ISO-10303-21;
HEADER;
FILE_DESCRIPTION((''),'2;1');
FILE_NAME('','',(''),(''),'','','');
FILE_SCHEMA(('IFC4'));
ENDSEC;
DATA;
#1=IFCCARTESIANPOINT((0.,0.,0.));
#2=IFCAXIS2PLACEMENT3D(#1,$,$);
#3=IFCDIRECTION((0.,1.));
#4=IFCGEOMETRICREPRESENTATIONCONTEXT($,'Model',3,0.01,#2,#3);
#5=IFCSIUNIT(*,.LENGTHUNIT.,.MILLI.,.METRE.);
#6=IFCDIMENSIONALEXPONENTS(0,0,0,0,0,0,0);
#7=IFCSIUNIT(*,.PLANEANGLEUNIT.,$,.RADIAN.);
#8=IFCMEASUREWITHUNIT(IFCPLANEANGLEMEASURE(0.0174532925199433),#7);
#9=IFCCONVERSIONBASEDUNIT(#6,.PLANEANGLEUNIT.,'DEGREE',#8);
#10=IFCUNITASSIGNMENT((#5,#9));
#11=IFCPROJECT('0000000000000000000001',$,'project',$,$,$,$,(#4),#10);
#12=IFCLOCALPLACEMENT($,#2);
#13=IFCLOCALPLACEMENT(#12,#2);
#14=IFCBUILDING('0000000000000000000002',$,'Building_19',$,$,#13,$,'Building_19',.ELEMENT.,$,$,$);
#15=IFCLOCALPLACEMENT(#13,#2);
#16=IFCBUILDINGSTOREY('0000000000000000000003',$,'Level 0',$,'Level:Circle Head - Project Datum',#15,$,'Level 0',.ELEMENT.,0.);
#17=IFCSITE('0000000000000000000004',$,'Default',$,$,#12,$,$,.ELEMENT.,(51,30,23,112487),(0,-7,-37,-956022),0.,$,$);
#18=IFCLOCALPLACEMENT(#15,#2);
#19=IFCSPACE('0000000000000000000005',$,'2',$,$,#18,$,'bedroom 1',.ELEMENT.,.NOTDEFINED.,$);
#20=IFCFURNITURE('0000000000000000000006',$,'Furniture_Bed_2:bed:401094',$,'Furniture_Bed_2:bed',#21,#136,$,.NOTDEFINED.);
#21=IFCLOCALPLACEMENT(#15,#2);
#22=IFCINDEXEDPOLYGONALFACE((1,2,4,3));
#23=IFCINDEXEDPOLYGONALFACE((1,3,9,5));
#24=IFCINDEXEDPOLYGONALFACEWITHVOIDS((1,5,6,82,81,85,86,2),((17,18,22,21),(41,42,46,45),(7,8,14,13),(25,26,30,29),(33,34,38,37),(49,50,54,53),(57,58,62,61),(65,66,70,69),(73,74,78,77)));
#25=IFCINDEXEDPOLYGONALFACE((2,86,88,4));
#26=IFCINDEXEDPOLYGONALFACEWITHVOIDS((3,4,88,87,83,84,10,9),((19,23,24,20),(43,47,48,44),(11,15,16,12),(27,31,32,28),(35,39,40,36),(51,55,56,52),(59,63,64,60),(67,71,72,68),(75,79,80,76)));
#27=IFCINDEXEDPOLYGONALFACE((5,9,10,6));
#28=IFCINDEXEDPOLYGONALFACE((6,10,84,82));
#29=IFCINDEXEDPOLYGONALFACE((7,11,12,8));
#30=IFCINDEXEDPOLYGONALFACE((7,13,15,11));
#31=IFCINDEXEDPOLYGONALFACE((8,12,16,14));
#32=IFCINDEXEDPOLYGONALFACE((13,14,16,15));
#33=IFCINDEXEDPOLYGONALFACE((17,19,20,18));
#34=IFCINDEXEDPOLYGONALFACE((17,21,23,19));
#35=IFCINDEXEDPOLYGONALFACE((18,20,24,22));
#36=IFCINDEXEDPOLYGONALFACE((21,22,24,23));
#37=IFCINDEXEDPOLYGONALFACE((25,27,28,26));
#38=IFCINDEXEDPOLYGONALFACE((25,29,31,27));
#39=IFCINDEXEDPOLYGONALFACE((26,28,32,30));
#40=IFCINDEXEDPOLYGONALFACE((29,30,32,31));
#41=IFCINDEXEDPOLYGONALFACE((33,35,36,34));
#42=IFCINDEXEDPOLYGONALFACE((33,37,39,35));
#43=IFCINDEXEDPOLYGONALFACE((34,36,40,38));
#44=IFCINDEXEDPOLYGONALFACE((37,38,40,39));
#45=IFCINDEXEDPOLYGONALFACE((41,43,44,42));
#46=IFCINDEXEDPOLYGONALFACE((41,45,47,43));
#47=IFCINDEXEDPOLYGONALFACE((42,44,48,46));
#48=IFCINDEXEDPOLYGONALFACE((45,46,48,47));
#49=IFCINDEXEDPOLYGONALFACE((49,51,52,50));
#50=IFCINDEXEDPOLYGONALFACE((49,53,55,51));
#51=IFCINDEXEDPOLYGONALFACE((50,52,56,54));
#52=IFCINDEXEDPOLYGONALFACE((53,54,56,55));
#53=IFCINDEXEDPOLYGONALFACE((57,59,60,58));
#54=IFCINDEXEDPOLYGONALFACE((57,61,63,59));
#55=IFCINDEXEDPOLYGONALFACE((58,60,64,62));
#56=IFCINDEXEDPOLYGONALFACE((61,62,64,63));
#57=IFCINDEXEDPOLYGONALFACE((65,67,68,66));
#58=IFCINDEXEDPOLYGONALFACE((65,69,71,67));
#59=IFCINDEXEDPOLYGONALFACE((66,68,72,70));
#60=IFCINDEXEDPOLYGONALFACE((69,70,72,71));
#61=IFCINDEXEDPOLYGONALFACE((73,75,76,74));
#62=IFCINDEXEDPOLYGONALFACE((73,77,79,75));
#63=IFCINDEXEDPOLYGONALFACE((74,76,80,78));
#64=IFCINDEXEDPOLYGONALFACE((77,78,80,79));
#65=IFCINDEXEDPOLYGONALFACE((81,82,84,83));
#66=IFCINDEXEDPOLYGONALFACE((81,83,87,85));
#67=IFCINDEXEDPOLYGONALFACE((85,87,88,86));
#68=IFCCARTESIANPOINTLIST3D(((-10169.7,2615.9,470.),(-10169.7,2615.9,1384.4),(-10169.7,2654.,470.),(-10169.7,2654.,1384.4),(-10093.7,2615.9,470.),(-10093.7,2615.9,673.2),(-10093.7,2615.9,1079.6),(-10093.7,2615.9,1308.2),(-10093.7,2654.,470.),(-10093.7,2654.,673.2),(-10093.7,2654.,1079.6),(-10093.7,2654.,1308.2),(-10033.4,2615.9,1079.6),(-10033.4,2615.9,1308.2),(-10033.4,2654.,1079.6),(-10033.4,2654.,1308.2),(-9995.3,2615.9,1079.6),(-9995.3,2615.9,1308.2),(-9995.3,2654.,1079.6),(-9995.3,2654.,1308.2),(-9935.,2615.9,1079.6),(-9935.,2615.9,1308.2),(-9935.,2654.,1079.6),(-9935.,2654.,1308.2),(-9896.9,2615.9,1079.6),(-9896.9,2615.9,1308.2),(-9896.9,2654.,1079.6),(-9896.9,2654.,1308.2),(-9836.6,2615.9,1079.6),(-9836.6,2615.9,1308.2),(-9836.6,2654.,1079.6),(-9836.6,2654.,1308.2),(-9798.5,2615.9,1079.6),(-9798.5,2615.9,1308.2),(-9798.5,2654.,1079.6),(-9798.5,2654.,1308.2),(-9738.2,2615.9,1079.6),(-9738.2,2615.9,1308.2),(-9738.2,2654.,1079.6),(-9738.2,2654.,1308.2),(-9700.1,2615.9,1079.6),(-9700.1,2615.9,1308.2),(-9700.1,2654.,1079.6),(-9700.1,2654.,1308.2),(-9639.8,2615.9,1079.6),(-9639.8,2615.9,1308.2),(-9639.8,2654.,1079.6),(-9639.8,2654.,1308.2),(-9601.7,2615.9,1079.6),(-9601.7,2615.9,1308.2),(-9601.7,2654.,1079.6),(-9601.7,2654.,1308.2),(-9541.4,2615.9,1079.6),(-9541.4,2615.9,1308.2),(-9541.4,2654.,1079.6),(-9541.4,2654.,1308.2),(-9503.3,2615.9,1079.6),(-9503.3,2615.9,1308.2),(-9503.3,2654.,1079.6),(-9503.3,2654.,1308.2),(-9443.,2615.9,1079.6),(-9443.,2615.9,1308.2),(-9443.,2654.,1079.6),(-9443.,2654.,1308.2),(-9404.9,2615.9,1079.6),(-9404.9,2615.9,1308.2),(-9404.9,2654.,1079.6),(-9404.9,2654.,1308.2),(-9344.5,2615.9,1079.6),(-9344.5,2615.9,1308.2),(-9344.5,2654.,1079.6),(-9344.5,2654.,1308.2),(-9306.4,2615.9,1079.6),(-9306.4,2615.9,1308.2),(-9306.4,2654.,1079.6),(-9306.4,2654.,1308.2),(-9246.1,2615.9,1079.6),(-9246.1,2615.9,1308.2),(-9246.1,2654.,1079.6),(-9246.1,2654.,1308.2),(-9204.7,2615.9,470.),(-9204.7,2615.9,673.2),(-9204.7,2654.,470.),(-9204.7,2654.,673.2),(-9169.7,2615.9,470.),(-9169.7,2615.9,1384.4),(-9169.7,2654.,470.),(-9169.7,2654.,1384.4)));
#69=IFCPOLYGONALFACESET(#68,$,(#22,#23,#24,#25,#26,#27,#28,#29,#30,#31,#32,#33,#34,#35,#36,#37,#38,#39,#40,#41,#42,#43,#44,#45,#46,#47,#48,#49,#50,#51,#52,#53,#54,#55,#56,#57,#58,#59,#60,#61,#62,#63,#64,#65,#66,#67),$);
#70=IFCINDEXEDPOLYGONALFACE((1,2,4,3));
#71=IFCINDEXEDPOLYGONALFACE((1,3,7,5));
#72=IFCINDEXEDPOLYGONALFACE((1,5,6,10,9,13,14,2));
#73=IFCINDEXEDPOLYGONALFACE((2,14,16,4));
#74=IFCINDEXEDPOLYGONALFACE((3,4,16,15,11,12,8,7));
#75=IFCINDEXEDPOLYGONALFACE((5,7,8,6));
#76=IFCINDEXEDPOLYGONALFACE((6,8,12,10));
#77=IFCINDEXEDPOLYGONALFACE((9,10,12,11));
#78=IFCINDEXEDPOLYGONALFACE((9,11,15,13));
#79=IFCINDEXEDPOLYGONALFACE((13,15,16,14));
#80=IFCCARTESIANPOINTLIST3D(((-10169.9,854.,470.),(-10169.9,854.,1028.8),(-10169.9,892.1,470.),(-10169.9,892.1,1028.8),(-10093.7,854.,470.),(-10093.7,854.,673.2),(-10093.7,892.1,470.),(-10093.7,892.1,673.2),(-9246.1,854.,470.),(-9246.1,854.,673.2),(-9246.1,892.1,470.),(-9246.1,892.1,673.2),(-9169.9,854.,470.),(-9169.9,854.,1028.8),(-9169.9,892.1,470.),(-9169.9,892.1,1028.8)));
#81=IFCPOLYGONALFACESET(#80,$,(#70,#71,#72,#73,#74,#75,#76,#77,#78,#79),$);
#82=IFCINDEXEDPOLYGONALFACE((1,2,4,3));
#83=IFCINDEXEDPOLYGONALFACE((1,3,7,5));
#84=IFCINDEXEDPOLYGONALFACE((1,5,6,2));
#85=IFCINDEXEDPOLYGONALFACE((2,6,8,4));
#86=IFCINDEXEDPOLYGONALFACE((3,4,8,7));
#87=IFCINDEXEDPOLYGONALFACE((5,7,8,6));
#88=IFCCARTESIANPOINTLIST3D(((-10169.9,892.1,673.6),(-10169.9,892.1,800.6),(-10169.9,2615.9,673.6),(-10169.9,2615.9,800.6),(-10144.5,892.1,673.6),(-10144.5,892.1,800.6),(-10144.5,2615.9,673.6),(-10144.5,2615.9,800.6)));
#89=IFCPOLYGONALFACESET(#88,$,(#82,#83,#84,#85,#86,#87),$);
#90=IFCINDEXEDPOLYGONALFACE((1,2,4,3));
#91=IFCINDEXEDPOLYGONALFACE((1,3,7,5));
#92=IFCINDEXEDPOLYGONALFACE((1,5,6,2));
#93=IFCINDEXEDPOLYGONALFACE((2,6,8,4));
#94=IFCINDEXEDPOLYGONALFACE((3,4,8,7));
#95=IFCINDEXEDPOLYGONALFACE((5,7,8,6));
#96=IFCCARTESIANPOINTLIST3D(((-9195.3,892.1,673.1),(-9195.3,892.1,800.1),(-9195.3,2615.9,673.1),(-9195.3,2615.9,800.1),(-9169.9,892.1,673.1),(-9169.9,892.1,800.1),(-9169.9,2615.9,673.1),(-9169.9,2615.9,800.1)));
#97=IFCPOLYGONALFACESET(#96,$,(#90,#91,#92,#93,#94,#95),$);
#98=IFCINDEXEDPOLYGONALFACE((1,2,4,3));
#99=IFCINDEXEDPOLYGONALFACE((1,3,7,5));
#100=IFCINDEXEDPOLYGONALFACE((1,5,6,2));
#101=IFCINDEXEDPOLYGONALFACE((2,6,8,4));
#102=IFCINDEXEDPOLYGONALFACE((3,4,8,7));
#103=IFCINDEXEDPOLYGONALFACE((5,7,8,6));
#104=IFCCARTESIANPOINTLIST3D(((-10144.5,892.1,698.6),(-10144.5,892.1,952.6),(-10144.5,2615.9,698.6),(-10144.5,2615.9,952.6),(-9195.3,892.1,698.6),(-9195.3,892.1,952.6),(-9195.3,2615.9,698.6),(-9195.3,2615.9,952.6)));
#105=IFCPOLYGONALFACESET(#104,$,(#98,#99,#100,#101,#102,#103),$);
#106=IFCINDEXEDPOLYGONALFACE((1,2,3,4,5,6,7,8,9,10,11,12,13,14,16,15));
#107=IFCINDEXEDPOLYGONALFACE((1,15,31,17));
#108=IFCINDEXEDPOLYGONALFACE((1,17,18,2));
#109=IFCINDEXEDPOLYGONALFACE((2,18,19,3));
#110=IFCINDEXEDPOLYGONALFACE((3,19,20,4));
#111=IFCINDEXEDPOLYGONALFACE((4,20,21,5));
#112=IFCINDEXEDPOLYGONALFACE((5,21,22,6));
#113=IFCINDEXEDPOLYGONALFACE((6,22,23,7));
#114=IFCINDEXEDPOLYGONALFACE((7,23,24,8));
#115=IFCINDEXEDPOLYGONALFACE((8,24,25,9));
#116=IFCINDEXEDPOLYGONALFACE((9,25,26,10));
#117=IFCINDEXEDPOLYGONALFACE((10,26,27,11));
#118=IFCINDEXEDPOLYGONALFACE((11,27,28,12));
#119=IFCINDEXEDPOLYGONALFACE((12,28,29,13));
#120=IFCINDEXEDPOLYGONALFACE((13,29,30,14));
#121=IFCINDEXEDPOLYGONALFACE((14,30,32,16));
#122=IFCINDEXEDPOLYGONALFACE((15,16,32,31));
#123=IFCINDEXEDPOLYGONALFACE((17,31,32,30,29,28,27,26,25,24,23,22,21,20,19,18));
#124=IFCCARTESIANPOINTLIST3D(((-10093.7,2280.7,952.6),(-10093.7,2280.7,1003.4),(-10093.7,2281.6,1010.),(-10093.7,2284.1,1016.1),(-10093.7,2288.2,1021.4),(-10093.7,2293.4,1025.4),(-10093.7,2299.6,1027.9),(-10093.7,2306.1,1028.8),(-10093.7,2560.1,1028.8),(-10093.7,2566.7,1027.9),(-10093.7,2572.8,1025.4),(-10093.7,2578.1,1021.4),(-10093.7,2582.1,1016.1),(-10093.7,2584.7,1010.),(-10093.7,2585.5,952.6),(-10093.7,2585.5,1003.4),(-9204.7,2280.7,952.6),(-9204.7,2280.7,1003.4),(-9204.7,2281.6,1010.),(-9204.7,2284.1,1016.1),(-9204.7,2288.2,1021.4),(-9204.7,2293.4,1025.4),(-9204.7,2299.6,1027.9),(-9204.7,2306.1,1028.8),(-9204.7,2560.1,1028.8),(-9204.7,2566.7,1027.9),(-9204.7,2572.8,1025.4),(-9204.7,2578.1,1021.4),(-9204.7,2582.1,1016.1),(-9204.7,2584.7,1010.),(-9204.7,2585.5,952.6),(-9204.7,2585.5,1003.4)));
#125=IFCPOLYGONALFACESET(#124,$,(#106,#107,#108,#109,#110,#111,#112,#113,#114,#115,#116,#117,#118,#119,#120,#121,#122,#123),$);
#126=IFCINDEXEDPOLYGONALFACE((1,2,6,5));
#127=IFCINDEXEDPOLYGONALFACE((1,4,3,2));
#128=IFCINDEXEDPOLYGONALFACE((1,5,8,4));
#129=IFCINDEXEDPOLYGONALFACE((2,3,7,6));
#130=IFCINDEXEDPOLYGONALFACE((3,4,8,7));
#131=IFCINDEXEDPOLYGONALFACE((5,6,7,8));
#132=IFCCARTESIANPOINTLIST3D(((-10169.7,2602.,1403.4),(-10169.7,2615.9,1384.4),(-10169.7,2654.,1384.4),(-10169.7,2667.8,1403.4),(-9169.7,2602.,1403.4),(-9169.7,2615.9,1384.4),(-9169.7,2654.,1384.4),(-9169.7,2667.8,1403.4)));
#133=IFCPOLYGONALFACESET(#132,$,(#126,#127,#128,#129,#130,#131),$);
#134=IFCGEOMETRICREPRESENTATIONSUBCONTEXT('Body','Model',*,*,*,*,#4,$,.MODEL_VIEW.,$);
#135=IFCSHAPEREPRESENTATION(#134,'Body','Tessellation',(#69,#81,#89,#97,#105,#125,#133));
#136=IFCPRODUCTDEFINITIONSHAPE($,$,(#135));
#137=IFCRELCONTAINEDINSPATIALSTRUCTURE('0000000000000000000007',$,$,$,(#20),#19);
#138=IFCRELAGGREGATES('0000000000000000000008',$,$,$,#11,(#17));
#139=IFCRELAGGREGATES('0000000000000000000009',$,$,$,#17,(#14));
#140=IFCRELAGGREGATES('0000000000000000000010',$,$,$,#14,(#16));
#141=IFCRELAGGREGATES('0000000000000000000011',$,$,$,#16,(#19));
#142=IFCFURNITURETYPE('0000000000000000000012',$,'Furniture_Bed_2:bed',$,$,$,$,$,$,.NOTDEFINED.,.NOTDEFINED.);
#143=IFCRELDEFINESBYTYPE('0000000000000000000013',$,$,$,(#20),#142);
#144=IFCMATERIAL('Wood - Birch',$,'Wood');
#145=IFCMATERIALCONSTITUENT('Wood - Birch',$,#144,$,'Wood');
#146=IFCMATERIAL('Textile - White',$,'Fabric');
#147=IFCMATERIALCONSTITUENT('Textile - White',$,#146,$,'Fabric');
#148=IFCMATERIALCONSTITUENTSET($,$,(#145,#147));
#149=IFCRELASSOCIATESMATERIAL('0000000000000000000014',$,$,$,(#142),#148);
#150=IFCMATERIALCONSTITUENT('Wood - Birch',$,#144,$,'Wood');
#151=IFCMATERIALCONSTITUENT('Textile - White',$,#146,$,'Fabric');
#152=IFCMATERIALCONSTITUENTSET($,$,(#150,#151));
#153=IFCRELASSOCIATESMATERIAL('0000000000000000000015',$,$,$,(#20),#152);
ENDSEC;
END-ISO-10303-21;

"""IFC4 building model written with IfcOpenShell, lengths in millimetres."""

from ifc_helpers import new_model, entity, si_unit, converted_unit, direction, frame, origin, place, context, subcontext, project, spatial, line, arc, indexed_curve, outline, extrude, source, transform, mapped, material, constituent, constituent_set, type_object, type_shapes, element, save


model = new_model("IFC4")

# Units and contexts
model_context = context("Model", 3, precision=0.01, world=origin(), true_north=direction((0.0, 1.0)))
body_context = subcontext(model_context, "Body", "Model", "MODEL_VIEW")
ifc_project = project(units=[si_unit("LENGTHUNIT", "METRE", prefix="MILLI"), converted_unit("PLANEANGLEUNIT", "DEGREE", entity("IfcPlaneAngleMeasure", 0.0174532925199433), si_unit("PLANEANGLEUNIT", "RADIAN"), dimensions=[0, 0, 0, 0, 0, 0, 0])], contexts=[model_context])

# Site, building, storey
site_placement = place(None, origin())
site = spatial("IfcSite", under=ifc_project, at=site_placement, Name="Default", CompositionType="ELEMENT", RefLatitude=(51, 30, 23, 112487), RefLongitude=(0, -7, -37, -956022), RefElevation=0.0)
building_placement = place(site_placement, origin())
building = spatial("IfcBuilding", under=site, at=building_placement, Name="Building_19", LongName="Building_19", CompositionType="ELEMENT")
storey_placement = place(building_placement, origin())
storey = spatial("IfcBuildingStorey", under=building, at=storey_placement, Name="Level 0", ObjectType="Level:Circle Head - Project Datum", LongName="Level 0", CompositionType="ELEMENT", Elevation=0.0)

# Shared definitions
space_placement = place(storey_placement, origin())
space = spatial("IfcSpace", under=storey, at=space_placement, Name="2", LongName="bedroom 1", CompositionType="ELEMENT", PredefinedType="NOTDEFINED")

# Furniture
ifc_material_1 = material(Name="Wood - Birch", Category="Wood")
ifc_constituent_1 = constituent(ifc_material_1, Name="Wood - Birch", Category="Wood")
ifc_material_2 = material(Name="Textile - White", Category="Fabric")
ifc_constituent_2 = constituent(ifc_material_2, Name="Textile - White", Category="Fabric")
ifc_constituent_set_1 = constituent_set(constituents=[ifc_constituent_1, ifc_constituent_2])
ifc_constituent_3 = constituent(ifc_material_1, Name="Wood - Birch", Category="Wood")
ifc_constituent_4 = constituent(ifc_material_2, Name="Textile - White", Category="Fabric")
ifc_constituent_set_2 = constituent_set(constituents=[ifc_constituent_3, ifc_constituent_4])
furniture_type = type_object("IfcFurnitureType", Name="Furniture_Bed_2:bed", AssemblyPlace="NOTDEFINED", PredefinedType="NOTDEFINED", material=ifc_constituent_set_2)
shared_shape_1 = source(origin(), body_context, "Body", "SweptSolid", [
    extrude(outline(indexed_curve([(-635.0, -489.8), (279.4, -489.8), (279.4, -454.7), (76.2, -454.7), (76.2, 434.3), (279.4, 434.3), (279.4, 510.3), (-635.0, 510.3), (-635.0, -489.8)], self_intersect=False), holes=[indexed_curve([(-558.8, 374.0), (-558.8, 434.3), (-330.2, 434.3), (-330.2, 374.0), (-558.8, 374.0)], self_intersect=False), indexed_curve([(-558.8, 275.5), (-558.8, 335.9), (-330.2, 335.9), (-330.2, 275.5), (-558.8, 275.5)], self_intersect=False), indexed_curve([(-558.8, 177.1), (-558.8, 237.4), (-330.2, 237.4), (-330.2, 177.1), (-558.8, 177.1)], self_intersect=False), indexed_curve([(-558.8, 78.7), (-558.8, 139.0), (-330.2, 139.0), (-330.2, 78.7), (-558.8, 78.7)], self_intersect=False), indexed_curve([(-558.8, -118.1), (-558.8, -57.8), (-330.2, -57.8), (-330.2, -118.1), (-558.8, -118.1)], self_intersect=False), indexed_curve([(-558.8, -216.5), (-558.8, -156.2), (-330.2, -156.2), (-330.2, -216.5), (-558.8, -216.5)], self_intersect=False), indexed_curve([(-558.8, -314.9), (-558.8, -254.6), (-330.2, -254.6), (-330.2, -314.9), (-558.8, -314.9)], self_intersect=False), indexed_curve([(-558.8, -413.3), (-558.8, -353.0), (-330.2, -353.0), (-330.2, -413.3), (-558.8, -413.3)], self_intersect=False), indexed_curve([(-558.8, -19.7), (-558.8, 40.6), (-330.2, 40.6), (-330.2, -19.7), (-558.8, -19.7)], self_intersect=False)]), frame((-8.6, -38.1, 279.4), z_axis=(0.0, 1.0, 0.0), x_axis=(0.0, 0.0, -1.0)), (0.0, 0.0, 1.0), 38.1),
    extrude(outline(indexed_curve([(423.8, -190.5), (500.0, -190.5), (500.0, 368.3), (-500.0, 368.3), (-500.0, -190.5), (-423.8, -190.5), (-423.8, 12.7), (423.8, 12.7), (423.8, -190.5)], self_intersect=False)), frame((-19.1, -1800.0, 190.5), z_axis=(0.0, 1.0, 0.0), x_axis=(-1.0, 0.0, 0.0)), (0.0, 0.0, 1.0), 38.1),
    extrude(outline(indexed_curve([(-12.7, -861.9), (12.7, -861.9), (12.7, 861.9), (-12.7, 861.9), (-12.7, -861.9)], self_intersect=False)), frame((-506.4, -900.0, 203.6)), (0.0, 0.0, 1.0), 127.0),
    extrude(outline(indexed_curve([(-12.7, -861.9), (12.7, -861.9), (12.7, 861.9), (-12.7, 861.9), (-12.7, -861.9)], self_intersect=False)), frame((468.2, -900.0, 203.1)), (0.0, 0.0, 1.0), 127.0),
    extrude(outline(indexed_curve([(-474.6, -861.9), (474.6, -861.9), (474.6, 861.9), (-474.6, 861.9), (-474.6, -861.9)], self_intersect=False)), frame((-19.0, -900.0, 228.6), z_axis=(0.0, 0.0, 1.0), x_axis=(-1.0, 0.0, 0.0)), (0.0, 0.0, 1.0), 254.0),
    extrude(outline(indexed_curve([(-152.4, -42.3), (152.4, -42.3), (152.4, 8.5), (145.0, 26.4), (127.0, 33.9), (-127.0, 33.9), (-145.0, 26.4), (-152.4, 8.5)], segments=[line(1, 2, 3), arc(3, 4, 5), line(5, 6), arc(6, 7, 8), line(8, 1)], self_intersect=False)), frame((-442.9, -220.8, 524.9), z_axis=(1.0, 0.0, 0.0), x_axis=(0.0, 1.0, 0.0)), (0.0, 0.0, 1.0), 889.0),
    extrude(outline(indexed_curve([(-19.1, -9.5), (19.0, -9.5), (32.9, 9.5), (-32.9, 9.5), (-19.1, -9.5)], self_intersect=False)), frame((-518.8, -19.0, 923.9), z_axis=(1.0, 0.0, 0.0), x_axis=(0.0, 1.0, 0.0)), (0.0, 0.0, 1.0), 1000.1),
])
type_shapes(furniture_type, [shared_shape_1])
furniture_placement = place(space_placement, frame((-9650.9, 2654.0, 470.0)))
element("IfcFurniture", 1, at=furniture_placement, inside=space, type_object=furniture_type, material=ifc_constituent_set_1, Name="Furniture_Bed_2:bed:401094", ObjectType="Furniture_Bed_2:bed", PredefinedType="NOTDEFINED", context=body_context, shape_type="MappedRepresentation", body=[
    mapped(shared_shape_1, transform((0.0, 0.0, 0.0), scale=1.0)),
])

save(model, "model.ifc")
